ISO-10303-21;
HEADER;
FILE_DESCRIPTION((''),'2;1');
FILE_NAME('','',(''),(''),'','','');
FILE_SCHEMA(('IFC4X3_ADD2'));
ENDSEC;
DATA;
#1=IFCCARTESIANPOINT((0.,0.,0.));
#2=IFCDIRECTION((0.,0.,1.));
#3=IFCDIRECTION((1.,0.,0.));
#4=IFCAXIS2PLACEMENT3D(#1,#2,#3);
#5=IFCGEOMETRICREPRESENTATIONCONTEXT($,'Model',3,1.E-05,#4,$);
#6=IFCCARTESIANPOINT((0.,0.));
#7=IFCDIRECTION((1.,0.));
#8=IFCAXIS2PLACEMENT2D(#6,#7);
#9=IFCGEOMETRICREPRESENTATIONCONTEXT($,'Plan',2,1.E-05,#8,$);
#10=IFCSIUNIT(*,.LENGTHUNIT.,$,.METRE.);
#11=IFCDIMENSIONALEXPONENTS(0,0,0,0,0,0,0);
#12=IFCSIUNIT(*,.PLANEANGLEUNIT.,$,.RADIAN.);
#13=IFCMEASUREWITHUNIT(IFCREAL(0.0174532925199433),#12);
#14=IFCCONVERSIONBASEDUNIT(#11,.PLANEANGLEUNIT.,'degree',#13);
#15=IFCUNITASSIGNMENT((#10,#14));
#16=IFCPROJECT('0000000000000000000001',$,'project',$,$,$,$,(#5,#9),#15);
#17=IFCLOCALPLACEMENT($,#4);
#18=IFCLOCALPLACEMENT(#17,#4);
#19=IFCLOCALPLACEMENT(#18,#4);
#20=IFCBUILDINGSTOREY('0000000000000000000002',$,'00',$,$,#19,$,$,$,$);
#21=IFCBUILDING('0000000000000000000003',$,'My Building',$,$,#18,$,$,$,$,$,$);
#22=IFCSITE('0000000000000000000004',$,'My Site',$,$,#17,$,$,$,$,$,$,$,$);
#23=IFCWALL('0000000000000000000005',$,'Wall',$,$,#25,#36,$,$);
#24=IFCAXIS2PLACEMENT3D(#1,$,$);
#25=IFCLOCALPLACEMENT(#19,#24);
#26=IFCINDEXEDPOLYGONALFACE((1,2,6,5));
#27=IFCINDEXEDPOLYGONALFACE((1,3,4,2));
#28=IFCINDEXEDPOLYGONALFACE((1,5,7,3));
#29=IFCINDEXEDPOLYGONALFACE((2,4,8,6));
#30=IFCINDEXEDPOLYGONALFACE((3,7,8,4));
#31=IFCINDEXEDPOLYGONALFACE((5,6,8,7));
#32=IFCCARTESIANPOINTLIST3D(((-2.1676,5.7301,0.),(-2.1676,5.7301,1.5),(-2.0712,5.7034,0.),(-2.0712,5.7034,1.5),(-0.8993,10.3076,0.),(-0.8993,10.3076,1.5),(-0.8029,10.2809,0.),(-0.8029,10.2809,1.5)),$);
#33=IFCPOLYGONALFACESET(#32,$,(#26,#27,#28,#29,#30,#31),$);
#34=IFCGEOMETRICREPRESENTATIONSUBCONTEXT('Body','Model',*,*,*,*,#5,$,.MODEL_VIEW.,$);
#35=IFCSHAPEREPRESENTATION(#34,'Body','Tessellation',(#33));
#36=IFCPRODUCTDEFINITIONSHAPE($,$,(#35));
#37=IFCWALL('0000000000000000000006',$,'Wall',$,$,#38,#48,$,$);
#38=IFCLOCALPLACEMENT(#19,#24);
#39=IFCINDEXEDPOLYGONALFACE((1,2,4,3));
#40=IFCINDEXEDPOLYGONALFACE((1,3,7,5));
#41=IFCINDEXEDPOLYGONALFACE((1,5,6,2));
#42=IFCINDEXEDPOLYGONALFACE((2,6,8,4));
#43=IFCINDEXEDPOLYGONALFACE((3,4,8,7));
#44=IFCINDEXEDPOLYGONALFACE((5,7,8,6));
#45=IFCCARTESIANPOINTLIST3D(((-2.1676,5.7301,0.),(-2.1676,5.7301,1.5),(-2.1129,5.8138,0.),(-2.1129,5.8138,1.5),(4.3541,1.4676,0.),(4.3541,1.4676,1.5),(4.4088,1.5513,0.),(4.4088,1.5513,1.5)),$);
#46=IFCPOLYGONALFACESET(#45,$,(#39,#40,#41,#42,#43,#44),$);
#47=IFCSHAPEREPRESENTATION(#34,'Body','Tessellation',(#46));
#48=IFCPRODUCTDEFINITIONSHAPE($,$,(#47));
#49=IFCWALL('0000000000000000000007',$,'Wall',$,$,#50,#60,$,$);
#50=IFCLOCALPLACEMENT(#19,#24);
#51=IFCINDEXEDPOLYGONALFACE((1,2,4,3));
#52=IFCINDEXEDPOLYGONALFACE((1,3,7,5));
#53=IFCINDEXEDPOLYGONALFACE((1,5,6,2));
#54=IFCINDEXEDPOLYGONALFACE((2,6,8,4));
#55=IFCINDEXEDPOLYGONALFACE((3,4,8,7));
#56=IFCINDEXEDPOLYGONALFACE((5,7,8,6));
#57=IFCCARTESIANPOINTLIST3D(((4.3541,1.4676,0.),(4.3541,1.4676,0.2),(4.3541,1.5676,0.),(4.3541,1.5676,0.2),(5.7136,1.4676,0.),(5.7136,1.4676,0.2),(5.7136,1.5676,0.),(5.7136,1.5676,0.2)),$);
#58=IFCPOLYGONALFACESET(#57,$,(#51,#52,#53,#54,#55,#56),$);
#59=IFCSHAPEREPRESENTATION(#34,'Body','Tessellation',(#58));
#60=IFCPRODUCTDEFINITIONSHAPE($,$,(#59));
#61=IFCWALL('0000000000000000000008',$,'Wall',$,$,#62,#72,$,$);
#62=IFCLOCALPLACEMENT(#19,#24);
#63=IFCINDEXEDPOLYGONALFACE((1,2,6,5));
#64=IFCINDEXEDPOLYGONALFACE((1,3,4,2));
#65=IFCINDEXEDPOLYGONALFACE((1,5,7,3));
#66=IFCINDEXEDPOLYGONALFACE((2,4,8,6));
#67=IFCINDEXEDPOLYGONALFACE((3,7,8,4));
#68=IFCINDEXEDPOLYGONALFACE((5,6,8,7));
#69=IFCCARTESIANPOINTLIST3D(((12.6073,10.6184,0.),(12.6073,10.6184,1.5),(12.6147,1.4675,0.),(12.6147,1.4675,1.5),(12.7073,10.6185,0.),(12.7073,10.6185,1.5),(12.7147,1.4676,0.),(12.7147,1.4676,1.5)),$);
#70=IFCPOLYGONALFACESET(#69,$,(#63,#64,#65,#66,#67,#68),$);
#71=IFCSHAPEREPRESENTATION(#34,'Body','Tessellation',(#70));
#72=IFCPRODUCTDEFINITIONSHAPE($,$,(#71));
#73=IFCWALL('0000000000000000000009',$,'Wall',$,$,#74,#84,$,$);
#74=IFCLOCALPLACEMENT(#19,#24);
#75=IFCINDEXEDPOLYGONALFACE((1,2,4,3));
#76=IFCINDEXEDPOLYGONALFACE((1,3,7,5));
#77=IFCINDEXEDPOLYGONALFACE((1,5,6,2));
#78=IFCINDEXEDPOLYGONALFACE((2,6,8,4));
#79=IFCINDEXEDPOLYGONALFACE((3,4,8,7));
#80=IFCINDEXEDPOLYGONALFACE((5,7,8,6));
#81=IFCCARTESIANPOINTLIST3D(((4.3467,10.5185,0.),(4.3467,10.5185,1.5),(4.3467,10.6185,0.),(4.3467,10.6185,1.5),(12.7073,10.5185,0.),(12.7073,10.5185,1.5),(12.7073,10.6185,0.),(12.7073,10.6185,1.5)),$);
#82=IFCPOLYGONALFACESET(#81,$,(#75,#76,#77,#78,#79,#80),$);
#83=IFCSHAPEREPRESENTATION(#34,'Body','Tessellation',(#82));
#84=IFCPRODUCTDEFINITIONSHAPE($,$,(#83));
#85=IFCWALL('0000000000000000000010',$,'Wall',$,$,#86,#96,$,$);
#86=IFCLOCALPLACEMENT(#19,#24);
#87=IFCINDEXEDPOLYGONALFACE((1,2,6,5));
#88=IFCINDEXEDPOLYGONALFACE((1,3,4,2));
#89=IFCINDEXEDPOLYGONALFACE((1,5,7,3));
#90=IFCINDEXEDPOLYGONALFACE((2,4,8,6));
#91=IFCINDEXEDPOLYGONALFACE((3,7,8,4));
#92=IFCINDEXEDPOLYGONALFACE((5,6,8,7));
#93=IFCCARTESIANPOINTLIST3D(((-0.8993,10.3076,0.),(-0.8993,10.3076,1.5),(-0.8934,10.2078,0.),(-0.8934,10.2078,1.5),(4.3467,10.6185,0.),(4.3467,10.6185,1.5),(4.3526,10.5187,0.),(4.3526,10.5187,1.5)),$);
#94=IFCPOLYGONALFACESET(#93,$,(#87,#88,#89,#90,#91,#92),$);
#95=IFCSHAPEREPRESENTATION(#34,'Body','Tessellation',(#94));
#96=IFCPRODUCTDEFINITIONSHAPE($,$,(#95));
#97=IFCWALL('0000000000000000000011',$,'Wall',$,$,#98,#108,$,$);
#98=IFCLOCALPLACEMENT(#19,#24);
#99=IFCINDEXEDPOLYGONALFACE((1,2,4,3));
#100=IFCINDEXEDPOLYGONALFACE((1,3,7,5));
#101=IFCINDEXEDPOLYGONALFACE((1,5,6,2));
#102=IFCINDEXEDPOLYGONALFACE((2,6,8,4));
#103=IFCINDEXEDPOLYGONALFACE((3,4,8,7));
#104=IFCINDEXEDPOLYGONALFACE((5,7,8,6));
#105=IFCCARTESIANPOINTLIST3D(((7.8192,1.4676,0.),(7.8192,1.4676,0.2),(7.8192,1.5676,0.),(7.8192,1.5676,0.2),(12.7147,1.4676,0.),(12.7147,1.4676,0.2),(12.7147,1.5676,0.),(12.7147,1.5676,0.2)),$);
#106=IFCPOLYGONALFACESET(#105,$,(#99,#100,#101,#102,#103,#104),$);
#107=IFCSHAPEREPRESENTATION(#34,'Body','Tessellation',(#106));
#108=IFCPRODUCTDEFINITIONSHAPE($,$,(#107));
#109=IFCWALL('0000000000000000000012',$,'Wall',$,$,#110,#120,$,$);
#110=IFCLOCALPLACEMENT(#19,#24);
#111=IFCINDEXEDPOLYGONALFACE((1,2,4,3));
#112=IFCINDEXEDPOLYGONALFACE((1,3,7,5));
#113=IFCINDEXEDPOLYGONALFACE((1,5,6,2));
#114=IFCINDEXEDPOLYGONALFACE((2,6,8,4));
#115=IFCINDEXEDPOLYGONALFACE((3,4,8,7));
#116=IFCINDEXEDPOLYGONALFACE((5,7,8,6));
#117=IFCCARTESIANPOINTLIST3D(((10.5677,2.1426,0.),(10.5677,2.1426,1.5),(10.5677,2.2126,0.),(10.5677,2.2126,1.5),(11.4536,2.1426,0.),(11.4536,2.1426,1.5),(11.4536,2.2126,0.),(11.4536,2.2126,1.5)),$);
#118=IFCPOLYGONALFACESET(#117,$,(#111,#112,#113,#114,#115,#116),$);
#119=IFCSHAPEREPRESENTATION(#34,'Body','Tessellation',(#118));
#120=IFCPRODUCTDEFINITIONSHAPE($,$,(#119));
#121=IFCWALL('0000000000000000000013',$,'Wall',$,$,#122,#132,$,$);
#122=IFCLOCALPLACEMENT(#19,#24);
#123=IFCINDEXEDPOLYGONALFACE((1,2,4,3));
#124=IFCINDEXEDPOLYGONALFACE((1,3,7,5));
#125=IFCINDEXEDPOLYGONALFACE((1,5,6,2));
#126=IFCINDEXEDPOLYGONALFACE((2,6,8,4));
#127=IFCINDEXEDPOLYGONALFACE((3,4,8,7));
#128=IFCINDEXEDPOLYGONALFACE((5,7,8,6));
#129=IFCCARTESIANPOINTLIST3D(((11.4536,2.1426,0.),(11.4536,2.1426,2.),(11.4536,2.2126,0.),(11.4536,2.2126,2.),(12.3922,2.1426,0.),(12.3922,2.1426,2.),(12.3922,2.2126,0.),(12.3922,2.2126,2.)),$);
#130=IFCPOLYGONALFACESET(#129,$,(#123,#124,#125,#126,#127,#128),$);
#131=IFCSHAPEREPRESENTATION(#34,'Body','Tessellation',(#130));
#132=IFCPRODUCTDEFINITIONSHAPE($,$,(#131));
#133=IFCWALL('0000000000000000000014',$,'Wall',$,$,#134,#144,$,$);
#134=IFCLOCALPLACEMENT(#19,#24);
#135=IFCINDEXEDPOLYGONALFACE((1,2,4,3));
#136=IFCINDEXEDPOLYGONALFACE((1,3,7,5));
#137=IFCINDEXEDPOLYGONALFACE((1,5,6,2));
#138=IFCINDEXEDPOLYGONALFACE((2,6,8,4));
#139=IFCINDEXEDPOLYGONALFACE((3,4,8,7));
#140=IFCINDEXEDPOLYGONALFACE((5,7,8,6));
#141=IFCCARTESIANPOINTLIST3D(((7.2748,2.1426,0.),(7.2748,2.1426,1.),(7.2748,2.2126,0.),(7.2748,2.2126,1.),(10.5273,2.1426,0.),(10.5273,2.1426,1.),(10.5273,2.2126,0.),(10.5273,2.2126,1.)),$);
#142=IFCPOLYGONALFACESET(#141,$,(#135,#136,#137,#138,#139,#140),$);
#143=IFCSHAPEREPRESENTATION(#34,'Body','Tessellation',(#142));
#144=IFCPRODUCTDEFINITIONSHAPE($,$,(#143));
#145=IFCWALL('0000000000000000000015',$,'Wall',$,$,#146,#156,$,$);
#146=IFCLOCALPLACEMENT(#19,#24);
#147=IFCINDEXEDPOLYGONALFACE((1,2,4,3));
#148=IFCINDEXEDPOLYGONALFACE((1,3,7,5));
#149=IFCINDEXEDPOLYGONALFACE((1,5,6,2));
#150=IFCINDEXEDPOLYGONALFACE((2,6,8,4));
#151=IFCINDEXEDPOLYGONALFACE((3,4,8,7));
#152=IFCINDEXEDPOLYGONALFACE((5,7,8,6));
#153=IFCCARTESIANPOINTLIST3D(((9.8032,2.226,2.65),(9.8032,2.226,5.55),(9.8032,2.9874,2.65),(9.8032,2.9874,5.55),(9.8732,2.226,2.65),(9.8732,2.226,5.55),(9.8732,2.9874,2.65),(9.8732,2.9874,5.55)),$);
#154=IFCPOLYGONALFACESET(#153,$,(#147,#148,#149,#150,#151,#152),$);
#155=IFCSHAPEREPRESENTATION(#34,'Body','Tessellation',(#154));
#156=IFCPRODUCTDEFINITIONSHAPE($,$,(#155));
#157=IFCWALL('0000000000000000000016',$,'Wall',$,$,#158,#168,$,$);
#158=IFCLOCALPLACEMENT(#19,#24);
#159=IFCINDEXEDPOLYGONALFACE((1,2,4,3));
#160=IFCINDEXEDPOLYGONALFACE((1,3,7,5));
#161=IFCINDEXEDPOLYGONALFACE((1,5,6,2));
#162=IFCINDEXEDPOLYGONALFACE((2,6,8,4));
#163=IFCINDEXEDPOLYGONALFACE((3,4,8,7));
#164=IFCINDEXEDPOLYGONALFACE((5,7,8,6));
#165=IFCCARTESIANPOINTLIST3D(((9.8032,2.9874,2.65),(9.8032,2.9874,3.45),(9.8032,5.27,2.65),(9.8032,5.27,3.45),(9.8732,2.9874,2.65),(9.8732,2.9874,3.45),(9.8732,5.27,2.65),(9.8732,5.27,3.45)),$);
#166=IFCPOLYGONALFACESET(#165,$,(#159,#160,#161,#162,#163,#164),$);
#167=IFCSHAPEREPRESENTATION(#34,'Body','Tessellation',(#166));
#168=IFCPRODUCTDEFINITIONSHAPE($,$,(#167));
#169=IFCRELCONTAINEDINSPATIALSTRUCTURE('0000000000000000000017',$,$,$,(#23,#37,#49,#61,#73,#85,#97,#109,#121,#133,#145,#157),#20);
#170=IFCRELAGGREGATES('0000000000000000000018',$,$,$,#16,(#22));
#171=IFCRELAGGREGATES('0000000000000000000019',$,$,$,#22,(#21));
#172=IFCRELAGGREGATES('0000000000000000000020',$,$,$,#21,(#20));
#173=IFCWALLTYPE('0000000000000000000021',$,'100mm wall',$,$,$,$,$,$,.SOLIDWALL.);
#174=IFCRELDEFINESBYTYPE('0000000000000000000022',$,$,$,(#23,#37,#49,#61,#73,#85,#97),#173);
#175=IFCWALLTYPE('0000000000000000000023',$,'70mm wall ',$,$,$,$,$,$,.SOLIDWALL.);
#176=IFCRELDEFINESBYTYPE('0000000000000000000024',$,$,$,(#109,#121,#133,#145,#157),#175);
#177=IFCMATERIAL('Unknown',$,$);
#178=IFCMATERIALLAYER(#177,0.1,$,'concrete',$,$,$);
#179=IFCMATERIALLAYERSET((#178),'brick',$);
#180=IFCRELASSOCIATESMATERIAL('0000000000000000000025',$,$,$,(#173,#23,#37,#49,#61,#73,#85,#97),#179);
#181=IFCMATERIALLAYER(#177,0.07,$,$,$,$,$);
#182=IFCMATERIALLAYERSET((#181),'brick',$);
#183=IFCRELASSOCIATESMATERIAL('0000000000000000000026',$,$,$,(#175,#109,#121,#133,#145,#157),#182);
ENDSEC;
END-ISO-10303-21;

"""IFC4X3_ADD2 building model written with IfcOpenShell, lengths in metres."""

from ifc_helpers import new_model, entity, si_unit, converted_unit, frame, origin_with_axes, origin_2d_with_axis, place, context, subcontext, project, spatial, line, indexed_curve, outline, extrude, material, layer, layer_set, layer_usage, type_object, element, save


model = new_model("IFC4X3_ADD2")

# Units and contexts
model_context = context("Model", 3, precision=1e-05, world=origin_with_axes())
plan_context = context("Plan", 2, precision=1e-05, world=origin_2d_with_axis())
body_context = subcontext(model_context, "Body", "Model", "MODEL_VIEW")
ifc_project = project(units=[si_unit("LENGTHUNIT", "METRE"), converted_unit("PLANEANGLEUNIT", "degree", entity("IfcReal", 0.0174532925199433), si_unit("PLANEANGLEUNIT", "RADIAN"), dimensions=[0, 0, 0, 0, 0, 0, 0])], contexts=[model_context, plan_context])

# Site, building, storey
site_placement = place(None, origin_with_axes())
site = spatial("IfcSite", under=ifc_project, at=site_placement, Name="My Site")
building_placement = place(site_placement, origin_with_axes())
building = spatial("IfcBuilding", under=site, at=building_placement, Name="My Building")
storey_placement = place(building_placement, origin_with_axes())
storey = spatial("IfcBuildingStorey", under=building, at=storey_placement, Name="00")

# Walls
ifc_material = material(Name="Unknown")
ifc_layer_1 = layer(ifc_material, 0.1, Name="concrete")
ifc_layer_set_1 = layer_set([ifc_layer_1], Name="brick")
ifc_layer_usage_1 = layer_usage(ifc_layer_set_1, "AXIS2", "POSITIVE", 0.0)
wall_type_1 = type_object("IfcWallType", Name="100mm wall", PredefinedType="SOLIDWALL", material=ifc_layer_set_1)
wall_1_placement = place(storey_placement, frame((-0.8993, 10.3076, 0.0), z_axis=(0.0, 0.0, 1.0), x_axis=(-0.267012, -0.963693, 0.0)))
element("IfcWall", 1, at=wall_1_placement, inside=storey, type_object=wall_type_1, material=ifc_layer_usage_1, Name="Wall", context=body_context, shape_type="SweptSolid", body=[
    extrude(outline(indexed_curve([(0.0, 0.0), (0.0, 0.1), (4.75, 0.1), (4.75, 0.0)], segments=[line(1, 2, 3, 4, 1)])), origin_with_axes(), (0.0, 0.0, 1.0), 1.5),
])
ifc_layer_usage_2 = layer_usage(ifc_layer_set_1, "AXIS2", "POSITIVE", 0.0)
wall_2_placement = place(storey_placement, frame((-2.1676, 5.7301, 0.0), z_axis=(0.0, 0.0, 1.0), x_axis=(0.837068, -0.547098, 0.0)))
element("IfcWall", 2, at=wall_2_placement, inside=storey, type_object=wall_type_1, material=ifc_layer_usage_2, Name="Wall", context=body_context, shape_type="SweptSolid", body=[
    extrude(outline(indexed_curve([(0.0, 0.0), (0.0, 0.1), (7.7911, 0.1), (7.7911, 0.0)], segments=[line(1, 2, 3, 4, 1)])), origin_with_axes(), (0.0, 0.0, 1.0), 1.5),
])
ifc_layer_usage_3 = layer_usage(ifc_layer_set_1, "AXIS2", "POSITIVE", 0.0)
wall_3_placement = place(storey_placement, frame((4.3541, 1.4676, 0.0), z_axis=(0.0, 0.0, 1.0), x_axis=(1.0, 0.0, 0.0)))
element("IfcWall", 3, at=wall_3_placement, inside=storey, type_object=wall_type_1, material=ifc_layer_usage_3, Name="Wall", context=body_context, shape_type="SweptSolid", body=[
    extrude(outline(indexed_curve([(0.0, 0.0), (0.0, 0.1), (1.3596, 0.1), (1.3596, 0.0)], segments=[line(1, 2, 3, 4, 1)])), origin_with_axes(), (0.0, 0.0, 1.0), 0.2),
])
ifc_layer_usage_4 = layer_usage(ifc_layer_set_1, "AXIS2", "POSITIVE", 0.0)
wall_4_placement = place(storey_placement, frame((12.7147, 1.4676, 0.0), z_axis=(0.0, 0.0, 1.0), x_axis=(-0.000805, 1.0, 0.0)))
element("IfcWall", 4, at=wall_4_placement, inside=storey, type_object=wall_type_1, material=ifc_layer_usage_4, Name="Wall", context=body_context, shape_type="SweptSolid", body=[
    extrude(outline(indexed_curve([(0.0, 0.0), (0.0, 0.1), (9.1509, 0.1), (9.1509, 0.0)], segments=[line(1, 2, 3, 4, 1)])), origin_with_axes(), (0.0, 0.0, 1.0), 1.5),
])
ifc_layer_usage_5 = layer_usage(ifc_layer_set_1, "AXIS2", "POSITIVE", 0.0)
wall_5_placement = place(storey_placement, frame((12.7073, 10.6185, 0.0), z_axis=(0.0, 0.0, 1.0), x_axis=(-1.0, 0.0, 0.0)))
element("IfcWall", 5, at=wall_5_placement, inside=storey, type_object=wall_type_1, material=ifc_layer_usage_5, Name="Wall", context=body_context, shape_type="SweptSolid", body=[
    extrude(outline(indexed_curve([(0.0, 0.0), (0.0, 0.1), (8.3606, 0.1), (8.3606, 0.0)], segments=[line(1, 2, 3, 4, 1)])), origin_with_axes(), (0.0, 0.0, 1.0), 1.5),
])
ifc_layer_usage_6 = layer_usage(ifc_layer_set_1, "AXIS2", "POSITIVE", 0.0)
wall_6_placement = place(storey_placement, frame((4.3467, 10.6185, 0.0), z_axis=(0.0, 0.0, 1.0), x_axis=(-0.998249, -0.059157, 0.0)))
element("IfcWall", 6, at=wall_6_placement, inside=storey, type_object=wall_type_1, material=ifc_layer_usage_6, Name="Wall", context=body_context, shape_type="SweptSolid", body=[
    extrude(outline(indexed_curve([(0.0, 0.0), (0.0, 0.1), (5.2552, 0.1), (5.2552, 0.0)], segments=[line(1, 2, 3, 4, 1)])), origin_with_axes(), (0.0, 0.0, 1.0), 1.5),
])
ifc_layer_usage_7 = layer_usage(ifc_layer_set_1, "AXIS2", "POSITIVE", 0.0)
wall_7_placement = place(storey_placement, frame((7.8192, 1.4676, 0.0), z_axis=(0.0, 0.0, 1.0), x_axis=(1.0, 0.0, 0.0)))
element("IfcWall", 7, at=wall_7_placement, inside=storey, type_object=wall_type_1, material=ifc_layer_usage_7, Name="Wall", context=body_context, shape_type="SweptSolid", body=[
    extrude(outline(indexed_curve([(0.0, 0.0), (0.0, 0.1), (4.8954, 0.1), (4.8954, 0.0)], segments=[line(1, 2, 3, 4, 1)])), origin_with_axes(), (0.0, 0.0, 1.0), 0.2),
])
ifc_layer_2 = layer(ifc_material, 0.07)
ifc_layer_set_2 = layer_set([ifc_layer_2], Name="brick")
ifc_layer_usage_8 = layer_usage(ifc_layer_set_2, "AXIS2", "POSITIVE", 0.0)
wall_type_2 = type_object("IfcWallType", Name="70mm wall ", PredefinedType="SOLIDWALL", material=ifc_layer_set_2)
wall_8_placement = place(storey_placement, frame((10.5677, 2.1426, 0.0), z_axis=(0.0, 0.0, 1.0), x_axis=(1.0, 0.0, 0.0)))
element("IfcWall", 8, at=wall_8_placement, inside=storey, type_object=wall_type_2, material=ifc_layer_usage_8, Name="Wall", context=body_context, shape_type="SweptSolid", body=[
    extrude(outline(indexed_curve([(0.0, 0.0), (0.0, 0.07), (0.8859, 0.07), (0.8859, 0.0)], segments=[line(1, 2, 3, 4, 1)])), origin_with_axes(), (0.0, 0.0, 1.0), 1.5),
])
ifc_layer_usage_9 = layer_usage(ifc_layer_set_2, "AXIS2", "POSITIVE", 0.0)
wall_9_placement = place(storey_placement, frame((11.4536, 2.1426, 0.0), z_axis=(0.0, 0.0, 1.0), x_axis=(1.0, 0.0, 0.0)))
element("IfcWall", 9, at=wall_9_placement, inside=storey, type_object=wall_type_2, material=ifc_layer_usage_9, Name="Wall", context=body_context, shape_type="SweptSolid", body=[
    extrude(outline(indexed_curve([(0.0, 0.0), (0.0, 0.07), (0.9386, 0.07), (0.9386, 0.0)], segments=[line(1, 2, 3, 4, 1)])), origin_with_axes(), (0.0, 0.0, 1.0), 2.0),
])
ifc_layer_usage_10 = layer_usage(ifc_layer_set_2, "AXIS2", "POSITIVE", 0.0)
wall_10_placement = place(storey_placement, frame((7.2748, 2.1426, 0.0), z_axis=(0.0, 0.0, 1.0), x_axis=(1.0, 0.0, 0.0)))
element("IfcWall", 10, at=wall_10_placement, inside=storey, type_object=wall_type_2, material=ifc_layer_usage_10, Name="Wall", context=body_context, shape_type="SweptSolid", body=[
    extrude(outline(indexed_curve([(0.0, 0.0), (0.0, 0.07), (3.2525, 0.07), (3.2525, 0.0)], segments=[line(1, 2, 3, 4, 1)])), origin_with_axes(), (0.0, 0.0, 1.0), 1.0),
])
ifc_layer_usage_11 = layer_usage(ifc_layer_set_2, "AXIS2", "POSITIVE", 0.0)
wall_11_placement = place(storey_placement, frame((9.8732, 2.226, 2.65), z_axis=(0.0, 0.0, 1.0), x_axis=(0.0, 1.0, 0.0)))
element("IfcWall", 11, at=wall_11_placement, inside=storey, type_object=wall_type_2, material=ifc_layer_usage_11, Name="Wall", context=body_context, shape_type="SweptSolid", body=[
    extrude(outline(indexed_curve([(0.0, 0.0), (0.0, 0.07), (0.7614, 0.07), (0.7614, 0.0)], segments=[line(1, 2, 3, 4, 1)])), origin_with_axes(), (0.0, 0.0, 1.0), 2.9),
])
ifc_layer_usage_12 = layer_usage(ifc_layer_set_2, "AXIS2", "POSITIVE", 0.0)
wall_12_placement = place(storey_placement, frame((9.8732, 2.9874, 2.65), z_axis=(0.0, 0.0, 1.0), x_axis=(0.0, 1.0, 0.0)))
element("IfcWall", 12, at=wall_12_placement, inside=storey, type_object=wall_type_2, material=ifc_layer_usage_12, Name="Wall", context=body_context, shape_type="SweptSolid", body=[
    extrude(outline(indexed_curve([(0.0, 0.0), (0.0, 0.07), (2.2826, 0.07), (2.2826, 0.0)], segments=[line(1, 2, 3, 4, 1)])), origin_with_axes(), (0.0, 0.0, 1.0), 0.8),
])

save(model, "model.ifc")
